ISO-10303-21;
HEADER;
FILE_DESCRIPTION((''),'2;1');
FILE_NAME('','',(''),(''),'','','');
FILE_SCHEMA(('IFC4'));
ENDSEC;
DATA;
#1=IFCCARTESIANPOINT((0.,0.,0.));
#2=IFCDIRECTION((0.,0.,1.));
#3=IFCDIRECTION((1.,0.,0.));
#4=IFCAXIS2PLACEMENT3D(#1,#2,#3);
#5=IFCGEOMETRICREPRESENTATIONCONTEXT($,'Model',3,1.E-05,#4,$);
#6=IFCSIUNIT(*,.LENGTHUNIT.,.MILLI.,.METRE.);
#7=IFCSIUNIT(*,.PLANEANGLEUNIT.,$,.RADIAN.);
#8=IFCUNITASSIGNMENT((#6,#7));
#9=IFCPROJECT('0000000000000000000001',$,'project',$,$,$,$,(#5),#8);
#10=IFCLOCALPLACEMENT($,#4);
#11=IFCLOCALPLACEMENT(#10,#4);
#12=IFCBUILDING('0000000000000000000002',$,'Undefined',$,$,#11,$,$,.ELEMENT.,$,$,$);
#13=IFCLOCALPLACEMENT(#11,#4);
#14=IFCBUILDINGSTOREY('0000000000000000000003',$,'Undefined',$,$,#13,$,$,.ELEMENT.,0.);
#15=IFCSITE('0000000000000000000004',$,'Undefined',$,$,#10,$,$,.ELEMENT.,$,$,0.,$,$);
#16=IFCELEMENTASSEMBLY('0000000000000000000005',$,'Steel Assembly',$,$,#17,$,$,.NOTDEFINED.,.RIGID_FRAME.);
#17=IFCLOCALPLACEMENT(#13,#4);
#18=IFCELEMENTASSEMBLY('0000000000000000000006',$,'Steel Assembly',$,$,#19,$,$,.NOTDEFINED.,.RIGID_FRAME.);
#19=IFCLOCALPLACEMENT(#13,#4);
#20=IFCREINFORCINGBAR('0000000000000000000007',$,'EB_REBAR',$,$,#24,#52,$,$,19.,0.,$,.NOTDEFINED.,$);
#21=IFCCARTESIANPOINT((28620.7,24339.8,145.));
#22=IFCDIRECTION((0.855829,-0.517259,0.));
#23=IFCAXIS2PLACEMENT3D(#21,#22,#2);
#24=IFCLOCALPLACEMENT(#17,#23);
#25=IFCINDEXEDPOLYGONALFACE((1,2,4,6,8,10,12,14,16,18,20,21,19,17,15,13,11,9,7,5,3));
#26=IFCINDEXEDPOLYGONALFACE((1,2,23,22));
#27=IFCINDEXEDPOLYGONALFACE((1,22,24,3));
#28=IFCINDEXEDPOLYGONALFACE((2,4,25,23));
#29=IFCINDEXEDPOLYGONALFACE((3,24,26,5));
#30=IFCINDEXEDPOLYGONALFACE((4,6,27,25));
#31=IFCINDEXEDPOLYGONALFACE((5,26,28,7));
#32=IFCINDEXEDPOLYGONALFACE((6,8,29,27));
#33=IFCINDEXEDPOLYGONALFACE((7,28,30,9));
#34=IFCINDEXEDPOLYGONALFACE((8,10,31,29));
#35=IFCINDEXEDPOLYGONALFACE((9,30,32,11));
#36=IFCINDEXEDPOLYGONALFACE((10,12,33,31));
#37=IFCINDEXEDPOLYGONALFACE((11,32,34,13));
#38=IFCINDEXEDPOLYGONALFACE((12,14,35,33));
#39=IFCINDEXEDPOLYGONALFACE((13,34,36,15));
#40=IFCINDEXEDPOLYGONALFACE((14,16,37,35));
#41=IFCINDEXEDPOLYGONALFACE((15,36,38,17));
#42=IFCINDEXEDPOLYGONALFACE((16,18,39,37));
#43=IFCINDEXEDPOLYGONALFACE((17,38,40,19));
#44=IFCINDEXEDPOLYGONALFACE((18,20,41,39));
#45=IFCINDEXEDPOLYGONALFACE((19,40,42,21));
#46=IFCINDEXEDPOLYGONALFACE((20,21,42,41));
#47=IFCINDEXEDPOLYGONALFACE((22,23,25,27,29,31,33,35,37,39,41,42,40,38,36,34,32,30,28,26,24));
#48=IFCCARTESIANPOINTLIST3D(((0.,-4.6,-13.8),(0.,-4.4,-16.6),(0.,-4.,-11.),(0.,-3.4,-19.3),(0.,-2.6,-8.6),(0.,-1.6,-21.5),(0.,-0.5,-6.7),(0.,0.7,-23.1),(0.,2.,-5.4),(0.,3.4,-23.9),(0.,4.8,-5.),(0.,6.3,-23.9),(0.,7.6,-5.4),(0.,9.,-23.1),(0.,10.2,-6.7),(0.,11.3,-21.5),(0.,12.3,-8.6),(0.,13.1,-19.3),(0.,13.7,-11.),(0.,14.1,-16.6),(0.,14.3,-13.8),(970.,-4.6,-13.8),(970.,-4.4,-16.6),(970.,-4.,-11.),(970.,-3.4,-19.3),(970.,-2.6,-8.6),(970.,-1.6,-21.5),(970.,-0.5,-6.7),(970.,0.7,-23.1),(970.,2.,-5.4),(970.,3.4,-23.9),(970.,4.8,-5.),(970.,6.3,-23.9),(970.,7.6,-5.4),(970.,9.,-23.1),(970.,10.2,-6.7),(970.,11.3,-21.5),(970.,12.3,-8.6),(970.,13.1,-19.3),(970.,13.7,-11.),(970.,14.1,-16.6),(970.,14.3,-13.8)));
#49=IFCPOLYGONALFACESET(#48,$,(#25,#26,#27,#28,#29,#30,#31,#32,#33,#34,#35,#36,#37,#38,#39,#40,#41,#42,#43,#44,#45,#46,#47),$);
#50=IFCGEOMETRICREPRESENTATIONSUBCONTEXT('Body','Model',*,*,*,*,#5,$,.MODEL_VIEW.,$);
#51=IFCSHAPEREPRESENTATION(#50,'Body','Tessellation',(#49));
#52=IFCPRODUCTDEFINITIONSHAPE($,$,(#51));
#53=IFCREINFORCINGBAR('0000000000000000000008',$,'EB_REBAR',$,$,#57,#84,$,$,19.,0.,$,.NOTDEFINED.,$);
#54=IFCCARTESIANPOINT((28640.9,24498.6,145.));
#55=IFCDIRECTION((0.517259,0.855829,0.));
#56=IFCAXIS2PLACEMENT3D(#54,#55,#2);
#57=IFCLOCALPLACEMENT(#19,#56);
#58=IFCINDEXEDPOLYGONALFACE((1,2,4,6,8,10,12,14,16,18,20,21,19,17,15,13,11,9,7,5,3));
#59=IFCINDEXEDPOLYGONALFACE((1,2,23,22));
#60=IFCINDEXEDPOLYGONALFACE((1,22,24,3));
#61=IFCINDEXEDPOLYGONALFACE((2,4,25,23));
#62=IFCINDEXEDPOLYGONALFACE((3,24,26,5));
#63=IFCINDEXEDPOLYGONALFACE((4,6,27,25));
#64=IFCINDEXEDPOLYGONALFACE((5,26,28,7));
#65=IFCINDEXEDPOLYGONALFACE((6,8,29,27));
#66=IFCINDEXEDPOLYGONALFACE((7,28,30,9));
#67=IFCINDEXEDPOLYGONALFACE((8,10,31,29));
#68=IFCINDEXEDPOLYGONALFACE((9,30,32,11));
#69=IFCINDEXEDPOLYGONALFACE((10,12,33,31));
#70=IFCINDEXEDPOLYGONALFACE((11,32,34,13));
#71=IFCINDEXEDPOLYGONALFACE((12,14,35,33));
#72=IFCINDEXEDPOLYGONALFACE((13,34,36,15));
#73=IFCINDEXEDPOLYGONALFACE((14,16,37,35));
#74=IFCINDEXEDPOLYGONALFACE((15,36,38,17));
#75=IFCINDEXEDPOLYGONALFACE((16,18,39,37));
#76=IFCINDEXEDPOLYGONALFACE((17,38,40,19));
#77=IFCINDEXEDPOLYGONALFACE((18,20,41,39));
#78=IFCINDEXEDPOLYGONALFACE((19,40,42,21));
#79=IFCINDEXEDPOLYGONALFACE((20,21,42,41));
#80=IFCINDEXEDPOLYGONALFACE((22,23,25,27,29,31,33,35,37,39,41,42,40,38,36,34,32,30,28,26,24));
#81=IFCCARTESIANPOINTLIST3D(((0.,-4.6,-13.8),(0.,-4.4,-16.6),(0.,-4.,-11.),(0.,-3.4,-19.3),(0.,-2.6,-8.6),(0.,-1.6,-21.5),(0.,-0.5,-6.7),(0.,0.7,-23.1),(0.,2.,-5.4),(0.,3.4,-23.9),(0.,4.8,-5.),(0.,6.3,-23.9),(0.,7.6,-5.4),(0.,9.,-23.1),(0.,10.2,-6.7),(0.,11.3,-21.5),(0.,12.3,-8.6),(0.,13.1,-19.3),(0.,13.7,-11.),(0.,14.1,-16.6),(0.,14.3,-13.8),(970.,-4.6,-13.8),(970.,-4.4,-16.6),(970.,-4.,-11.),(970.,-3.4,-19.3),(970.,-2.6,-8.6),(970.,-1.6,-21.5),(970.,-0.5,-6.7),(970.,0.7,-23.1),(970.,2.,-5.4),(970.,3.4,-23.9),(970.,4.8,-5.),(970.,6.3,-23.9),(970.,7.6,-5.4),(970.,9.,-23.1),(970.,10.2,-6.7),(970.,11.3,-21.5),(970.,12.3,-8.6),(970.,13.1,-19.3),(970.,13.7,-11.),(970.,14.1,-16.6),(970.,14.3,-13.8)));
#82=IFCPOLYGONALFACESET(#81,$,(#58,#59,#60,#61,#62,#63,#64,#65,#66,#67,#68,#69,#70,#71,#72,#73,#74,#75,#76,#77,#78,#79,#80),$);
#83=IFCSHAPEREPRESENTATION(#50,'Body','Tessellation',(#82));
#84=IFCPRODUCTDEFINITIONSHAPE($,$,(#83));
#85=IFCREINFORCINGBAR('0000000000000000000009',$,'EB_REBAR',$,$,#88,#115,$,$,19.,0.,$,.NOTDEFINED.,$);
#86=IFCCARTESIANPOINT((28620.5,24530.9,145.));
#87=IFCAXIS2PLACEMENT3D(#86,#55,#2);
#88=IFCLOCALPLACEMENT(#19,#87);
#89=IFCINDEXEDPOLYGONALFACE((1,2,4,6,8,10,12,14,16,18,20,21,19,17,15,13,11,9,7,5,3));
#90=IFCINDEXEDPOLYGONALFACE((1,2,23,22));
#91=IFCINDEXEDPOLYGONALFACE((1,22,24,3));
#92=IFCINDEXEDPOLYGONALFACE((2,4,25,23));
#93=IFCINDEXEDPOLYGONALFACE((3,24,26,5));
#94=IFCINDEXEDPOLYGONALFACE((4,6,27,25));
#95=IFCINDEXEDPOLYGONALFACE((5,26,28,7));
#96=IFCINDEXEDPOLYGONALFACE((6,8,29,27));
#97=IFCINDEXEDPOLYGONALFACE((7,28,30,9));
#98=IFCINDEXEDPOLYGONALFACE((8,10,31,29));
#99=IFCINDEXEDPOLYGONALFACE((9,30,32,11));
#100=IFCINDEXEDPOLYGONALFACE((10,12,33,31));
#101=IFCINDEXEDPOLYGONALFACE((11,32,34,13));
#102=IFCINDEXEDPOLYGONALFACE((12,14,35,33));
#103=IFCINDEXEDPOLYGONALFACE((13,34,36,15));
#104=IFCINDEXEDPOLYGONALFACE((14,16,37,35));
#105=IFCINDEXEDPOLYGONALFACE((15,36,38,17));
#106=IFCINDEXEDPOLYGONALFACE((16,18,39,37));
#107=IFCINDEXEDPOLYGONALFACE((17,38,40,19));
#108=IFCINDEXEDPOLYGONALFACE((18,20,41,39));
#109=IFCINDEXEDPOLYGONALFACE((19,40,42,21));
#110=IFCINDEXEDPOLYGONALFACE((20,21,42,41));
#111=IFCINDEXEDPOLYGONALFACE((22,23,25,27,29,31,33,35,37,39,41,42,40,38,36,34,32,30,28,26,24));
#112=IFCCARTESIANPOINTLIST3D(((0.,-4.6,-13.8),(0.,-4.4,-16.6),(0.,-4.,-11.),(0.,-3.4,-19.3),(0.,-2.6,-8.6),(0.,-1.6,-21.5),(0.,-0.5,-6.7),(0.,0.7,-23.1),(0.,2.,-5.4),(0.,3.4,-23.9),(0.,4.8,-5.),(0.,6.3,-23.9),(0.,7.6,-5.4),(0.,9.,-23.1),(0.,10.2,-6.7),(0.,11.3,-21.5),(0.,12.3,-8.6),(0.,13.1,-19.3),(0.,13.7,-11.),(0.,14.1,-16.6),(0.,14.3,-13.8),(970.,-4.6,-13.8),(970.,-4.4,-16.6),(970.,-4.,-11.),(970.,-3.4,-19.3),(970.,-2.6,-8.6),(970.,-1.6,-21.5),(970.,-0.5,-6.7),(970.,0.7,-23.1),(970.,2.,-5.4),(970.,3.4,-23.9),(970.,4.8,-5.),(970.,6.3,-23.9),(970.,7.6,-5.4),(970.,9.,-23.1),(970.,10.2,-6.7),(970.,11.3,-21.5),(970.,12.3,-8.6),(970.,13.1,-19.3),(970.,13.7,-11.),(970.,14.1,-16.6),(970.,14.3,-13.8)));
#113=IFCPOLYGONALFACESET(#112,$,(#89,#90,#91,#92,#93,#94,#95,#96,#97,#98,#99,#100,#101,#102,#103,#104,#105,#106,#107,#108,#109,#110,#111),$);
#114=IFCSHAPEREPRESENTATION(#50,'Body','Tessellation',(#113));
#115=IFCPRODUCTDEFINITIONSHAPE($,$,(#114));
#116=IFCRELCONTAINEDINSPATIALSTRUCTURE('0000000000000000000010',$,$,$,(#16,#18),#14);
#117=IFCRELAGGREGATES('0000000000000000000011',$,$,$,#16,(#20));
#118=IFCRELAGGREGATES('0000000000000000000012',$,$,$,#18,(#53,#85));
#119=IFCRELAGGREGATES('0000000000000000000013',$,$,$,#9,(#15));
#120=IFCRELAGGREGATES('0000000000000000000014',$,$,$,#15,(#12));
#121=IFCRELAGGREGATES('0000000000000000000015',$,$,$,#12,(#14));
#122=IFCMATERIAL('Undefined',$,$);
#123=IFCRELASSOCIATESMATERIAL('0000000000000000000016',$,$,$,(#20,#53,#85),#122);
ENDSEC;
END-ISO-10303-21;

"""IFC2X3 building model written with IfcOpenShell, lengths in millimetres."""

from ifc_helpers import new_model, entity, si_unit, frame, origin_with_axes, place, context, subcontext, project, spatial, source, transform, mapped, material, element, aggregate, save


model = new_model("IFC2X3")

# Units and contexts
model_context = context("Model", 3, precision=1e-05, world=origin_with_axes())
body_context = subcontext(model_context, "Body", "Model", "MODEL_VIEW")
ifc_project = project(units=[si_unit("LENGTHUNIT", "METRE", prefix="MILLI"), si_unit("PLANEANGLEUNIT", "RADIAN")], contexts=[model_context])

# Site, building, storey
site_placement = place(None, origin_with_axes())
site = spatial("IfcSite", under=ifc_project, at=site_placement, Name="Undefined", CompositionType="ELEMENT", RefElevation=0.0)
building_placement = place(site_placement, origin_with_axes())
building = spatial("IfcBuilding", under=site, at=building_placement, Name="Undefined", CompositionType="ELEMENT")
storey_placement = place(building_placement, origin_with_axes())
storey = spatial("IfcBuildingStorey", under=building, at=storey_placement, Name="Undefined", CompositionType="ELEMENT", Elevation=0.0)

# Element assemblies
assembly_1_placement = place(storey_placement, origin_with_axes())
assembly_1 = element("IfcElementAssembly", 1, at=assembly_1_placement, inside=storey, Name="Steel Assembly", AssemblyPlace="NOTDEFINED", PredefinedType="RIGID_FRAME")
assembly_2_placement = place(storey_placement, origin_with_axes())
assembly_2 = element("IfcElementAssembly", 2, at=assembly_2_placement, inside=storey, Name="Steel Assembly", AssemblyPlace="NOTDEFINED", PredefinedType="RIGID_FRAME")

# Shared definitions
ifc_material_1 = material(Name="Undefined")

# Reinforcing bars
shared_shape_1 = source(origin_with_axes(), body_context, "Body", "AdvancedSweptSolid", [
    entity("IfcSweptDiskSolid", entity("IfcTrimmedCurve", entity("IfcLine", entity("IfcCartesianPoint", [0.0, 0.0, 0.0]), entity("IfcVector", entity("IfcDirection", [1.0, 0.0, 0.0]), 1.0)), [entity("IfcParameterValue", 0.0)], [entity("IfcParameterValue", 969.999905)], True, "PARAMETER"), 9.5, None, 0.0, 970.0),
])
reinforcing_bar_1_placement = place(assembly_1_placement, frame((28620.7, 24339.8, 145.0), z_axis=(0.855829, -0.517259, 0.0), x_axis=(0.0, 0.0, 1.0)))
reinforcing_bar_1 = element("IfcReinforcingBar", 3, at=reinforcing_bar_1_placement, material=ifc_material_1, Name="EB_REBAR", BarRole="NOTDEFINED", CrossSectionArea=0.0, NominalDiameter=19.0, context=body_context, shape_type="MappedRepresentation", body=[
    mapped(shared_shape_1, transform((0.0, 4.8, -14.5))),
])
aggregate(assembly_1, [reinforcing_bar_1])
shared_shape_2 = source(origin_with_axes(), body_context, "Body", "AdvancedSweptSolid", [
    entity("IfcSweptDiskSolid", entity("IfcTrimmedCurve", entity("IfcLine", entity("IfcCartesianPoint", [0.0, 0.0, 0.0]), entity("IfcVector", entity("IfcDirection", [1.0, 0.0, 0.0]), 1.0)), [entity("IfcParameterValue", 0.0)], [entity("IfcParameterValue", 969.999996)], True, "PARAMETER"), 9.5, None, 0.0, 970.0),
])
reinforcing_bar_2_placement = place(assembly_2_placement, frame((28640.9, 24498.6, 145.0), z_axis=(0.517259, 0.855829, 0.0), x_axis=(0.0, 0.0, 1.0)))
reinforcing_bar_2 = element("IfcReinforcingBar", 4, at=reinforcing_bar_2_placement, material=ifc_material_1, Name="EB_REBAR", BarRole="NOTDEFINED", CrossSectionArea=0.0, NominalDiameter=19.0, context=body_context, shape_type="MappedRepresentation", body=[
    mapped(shared_shape_2, transform((0.0, 4.8, -14.5))),
])
shared_shape_3 = source(origin_with_axes(), body_context, "Body", "AdvancedSweptSolid", [
    entity("IfcSweptDiskSolid", entity("IfcTrimmedCurve", entity("IfcLine", entity("IfcCartesianPoint", [0.0, 0.0, 0.0]), entity("IfcVector", entity("IfcDirection", [1.0, 0.0, 0.0]), 1.0)), [entity("IfcParameterValue", 0.0)], [entity("IfcParameterValue", 969.999905)], True, "PARAMETER"), 9.5, None, 0.0, 970.0),
])
reinforcing_bar_3_placement = place(assembly_2_placement, frame((28620.5, 24530.9, 145.0), z_axis=(0.517259, 0.855829, 0.0), x_axis=(0.0, 0.0, 1.0)))
reinforcing_bar_3 = element("IfcReinforcingBar", 5, at=reinforcing_bar_3_placement, material=ifc_material_1, Name="EB_REBAR", BarRole="NOTDEFINED", CrossSectionArea=0.0, NominalDiameter=19.0, context=body_context, shape_type="MappedRepresentation", body=[
    mapped(shared_shape_3, transform((0.0, 4.8, -14.5))),
])
aggregate(assembly_2, [reinforcing_bar_2, reinforcing_bar_3])

save(model, "model.ifc")
